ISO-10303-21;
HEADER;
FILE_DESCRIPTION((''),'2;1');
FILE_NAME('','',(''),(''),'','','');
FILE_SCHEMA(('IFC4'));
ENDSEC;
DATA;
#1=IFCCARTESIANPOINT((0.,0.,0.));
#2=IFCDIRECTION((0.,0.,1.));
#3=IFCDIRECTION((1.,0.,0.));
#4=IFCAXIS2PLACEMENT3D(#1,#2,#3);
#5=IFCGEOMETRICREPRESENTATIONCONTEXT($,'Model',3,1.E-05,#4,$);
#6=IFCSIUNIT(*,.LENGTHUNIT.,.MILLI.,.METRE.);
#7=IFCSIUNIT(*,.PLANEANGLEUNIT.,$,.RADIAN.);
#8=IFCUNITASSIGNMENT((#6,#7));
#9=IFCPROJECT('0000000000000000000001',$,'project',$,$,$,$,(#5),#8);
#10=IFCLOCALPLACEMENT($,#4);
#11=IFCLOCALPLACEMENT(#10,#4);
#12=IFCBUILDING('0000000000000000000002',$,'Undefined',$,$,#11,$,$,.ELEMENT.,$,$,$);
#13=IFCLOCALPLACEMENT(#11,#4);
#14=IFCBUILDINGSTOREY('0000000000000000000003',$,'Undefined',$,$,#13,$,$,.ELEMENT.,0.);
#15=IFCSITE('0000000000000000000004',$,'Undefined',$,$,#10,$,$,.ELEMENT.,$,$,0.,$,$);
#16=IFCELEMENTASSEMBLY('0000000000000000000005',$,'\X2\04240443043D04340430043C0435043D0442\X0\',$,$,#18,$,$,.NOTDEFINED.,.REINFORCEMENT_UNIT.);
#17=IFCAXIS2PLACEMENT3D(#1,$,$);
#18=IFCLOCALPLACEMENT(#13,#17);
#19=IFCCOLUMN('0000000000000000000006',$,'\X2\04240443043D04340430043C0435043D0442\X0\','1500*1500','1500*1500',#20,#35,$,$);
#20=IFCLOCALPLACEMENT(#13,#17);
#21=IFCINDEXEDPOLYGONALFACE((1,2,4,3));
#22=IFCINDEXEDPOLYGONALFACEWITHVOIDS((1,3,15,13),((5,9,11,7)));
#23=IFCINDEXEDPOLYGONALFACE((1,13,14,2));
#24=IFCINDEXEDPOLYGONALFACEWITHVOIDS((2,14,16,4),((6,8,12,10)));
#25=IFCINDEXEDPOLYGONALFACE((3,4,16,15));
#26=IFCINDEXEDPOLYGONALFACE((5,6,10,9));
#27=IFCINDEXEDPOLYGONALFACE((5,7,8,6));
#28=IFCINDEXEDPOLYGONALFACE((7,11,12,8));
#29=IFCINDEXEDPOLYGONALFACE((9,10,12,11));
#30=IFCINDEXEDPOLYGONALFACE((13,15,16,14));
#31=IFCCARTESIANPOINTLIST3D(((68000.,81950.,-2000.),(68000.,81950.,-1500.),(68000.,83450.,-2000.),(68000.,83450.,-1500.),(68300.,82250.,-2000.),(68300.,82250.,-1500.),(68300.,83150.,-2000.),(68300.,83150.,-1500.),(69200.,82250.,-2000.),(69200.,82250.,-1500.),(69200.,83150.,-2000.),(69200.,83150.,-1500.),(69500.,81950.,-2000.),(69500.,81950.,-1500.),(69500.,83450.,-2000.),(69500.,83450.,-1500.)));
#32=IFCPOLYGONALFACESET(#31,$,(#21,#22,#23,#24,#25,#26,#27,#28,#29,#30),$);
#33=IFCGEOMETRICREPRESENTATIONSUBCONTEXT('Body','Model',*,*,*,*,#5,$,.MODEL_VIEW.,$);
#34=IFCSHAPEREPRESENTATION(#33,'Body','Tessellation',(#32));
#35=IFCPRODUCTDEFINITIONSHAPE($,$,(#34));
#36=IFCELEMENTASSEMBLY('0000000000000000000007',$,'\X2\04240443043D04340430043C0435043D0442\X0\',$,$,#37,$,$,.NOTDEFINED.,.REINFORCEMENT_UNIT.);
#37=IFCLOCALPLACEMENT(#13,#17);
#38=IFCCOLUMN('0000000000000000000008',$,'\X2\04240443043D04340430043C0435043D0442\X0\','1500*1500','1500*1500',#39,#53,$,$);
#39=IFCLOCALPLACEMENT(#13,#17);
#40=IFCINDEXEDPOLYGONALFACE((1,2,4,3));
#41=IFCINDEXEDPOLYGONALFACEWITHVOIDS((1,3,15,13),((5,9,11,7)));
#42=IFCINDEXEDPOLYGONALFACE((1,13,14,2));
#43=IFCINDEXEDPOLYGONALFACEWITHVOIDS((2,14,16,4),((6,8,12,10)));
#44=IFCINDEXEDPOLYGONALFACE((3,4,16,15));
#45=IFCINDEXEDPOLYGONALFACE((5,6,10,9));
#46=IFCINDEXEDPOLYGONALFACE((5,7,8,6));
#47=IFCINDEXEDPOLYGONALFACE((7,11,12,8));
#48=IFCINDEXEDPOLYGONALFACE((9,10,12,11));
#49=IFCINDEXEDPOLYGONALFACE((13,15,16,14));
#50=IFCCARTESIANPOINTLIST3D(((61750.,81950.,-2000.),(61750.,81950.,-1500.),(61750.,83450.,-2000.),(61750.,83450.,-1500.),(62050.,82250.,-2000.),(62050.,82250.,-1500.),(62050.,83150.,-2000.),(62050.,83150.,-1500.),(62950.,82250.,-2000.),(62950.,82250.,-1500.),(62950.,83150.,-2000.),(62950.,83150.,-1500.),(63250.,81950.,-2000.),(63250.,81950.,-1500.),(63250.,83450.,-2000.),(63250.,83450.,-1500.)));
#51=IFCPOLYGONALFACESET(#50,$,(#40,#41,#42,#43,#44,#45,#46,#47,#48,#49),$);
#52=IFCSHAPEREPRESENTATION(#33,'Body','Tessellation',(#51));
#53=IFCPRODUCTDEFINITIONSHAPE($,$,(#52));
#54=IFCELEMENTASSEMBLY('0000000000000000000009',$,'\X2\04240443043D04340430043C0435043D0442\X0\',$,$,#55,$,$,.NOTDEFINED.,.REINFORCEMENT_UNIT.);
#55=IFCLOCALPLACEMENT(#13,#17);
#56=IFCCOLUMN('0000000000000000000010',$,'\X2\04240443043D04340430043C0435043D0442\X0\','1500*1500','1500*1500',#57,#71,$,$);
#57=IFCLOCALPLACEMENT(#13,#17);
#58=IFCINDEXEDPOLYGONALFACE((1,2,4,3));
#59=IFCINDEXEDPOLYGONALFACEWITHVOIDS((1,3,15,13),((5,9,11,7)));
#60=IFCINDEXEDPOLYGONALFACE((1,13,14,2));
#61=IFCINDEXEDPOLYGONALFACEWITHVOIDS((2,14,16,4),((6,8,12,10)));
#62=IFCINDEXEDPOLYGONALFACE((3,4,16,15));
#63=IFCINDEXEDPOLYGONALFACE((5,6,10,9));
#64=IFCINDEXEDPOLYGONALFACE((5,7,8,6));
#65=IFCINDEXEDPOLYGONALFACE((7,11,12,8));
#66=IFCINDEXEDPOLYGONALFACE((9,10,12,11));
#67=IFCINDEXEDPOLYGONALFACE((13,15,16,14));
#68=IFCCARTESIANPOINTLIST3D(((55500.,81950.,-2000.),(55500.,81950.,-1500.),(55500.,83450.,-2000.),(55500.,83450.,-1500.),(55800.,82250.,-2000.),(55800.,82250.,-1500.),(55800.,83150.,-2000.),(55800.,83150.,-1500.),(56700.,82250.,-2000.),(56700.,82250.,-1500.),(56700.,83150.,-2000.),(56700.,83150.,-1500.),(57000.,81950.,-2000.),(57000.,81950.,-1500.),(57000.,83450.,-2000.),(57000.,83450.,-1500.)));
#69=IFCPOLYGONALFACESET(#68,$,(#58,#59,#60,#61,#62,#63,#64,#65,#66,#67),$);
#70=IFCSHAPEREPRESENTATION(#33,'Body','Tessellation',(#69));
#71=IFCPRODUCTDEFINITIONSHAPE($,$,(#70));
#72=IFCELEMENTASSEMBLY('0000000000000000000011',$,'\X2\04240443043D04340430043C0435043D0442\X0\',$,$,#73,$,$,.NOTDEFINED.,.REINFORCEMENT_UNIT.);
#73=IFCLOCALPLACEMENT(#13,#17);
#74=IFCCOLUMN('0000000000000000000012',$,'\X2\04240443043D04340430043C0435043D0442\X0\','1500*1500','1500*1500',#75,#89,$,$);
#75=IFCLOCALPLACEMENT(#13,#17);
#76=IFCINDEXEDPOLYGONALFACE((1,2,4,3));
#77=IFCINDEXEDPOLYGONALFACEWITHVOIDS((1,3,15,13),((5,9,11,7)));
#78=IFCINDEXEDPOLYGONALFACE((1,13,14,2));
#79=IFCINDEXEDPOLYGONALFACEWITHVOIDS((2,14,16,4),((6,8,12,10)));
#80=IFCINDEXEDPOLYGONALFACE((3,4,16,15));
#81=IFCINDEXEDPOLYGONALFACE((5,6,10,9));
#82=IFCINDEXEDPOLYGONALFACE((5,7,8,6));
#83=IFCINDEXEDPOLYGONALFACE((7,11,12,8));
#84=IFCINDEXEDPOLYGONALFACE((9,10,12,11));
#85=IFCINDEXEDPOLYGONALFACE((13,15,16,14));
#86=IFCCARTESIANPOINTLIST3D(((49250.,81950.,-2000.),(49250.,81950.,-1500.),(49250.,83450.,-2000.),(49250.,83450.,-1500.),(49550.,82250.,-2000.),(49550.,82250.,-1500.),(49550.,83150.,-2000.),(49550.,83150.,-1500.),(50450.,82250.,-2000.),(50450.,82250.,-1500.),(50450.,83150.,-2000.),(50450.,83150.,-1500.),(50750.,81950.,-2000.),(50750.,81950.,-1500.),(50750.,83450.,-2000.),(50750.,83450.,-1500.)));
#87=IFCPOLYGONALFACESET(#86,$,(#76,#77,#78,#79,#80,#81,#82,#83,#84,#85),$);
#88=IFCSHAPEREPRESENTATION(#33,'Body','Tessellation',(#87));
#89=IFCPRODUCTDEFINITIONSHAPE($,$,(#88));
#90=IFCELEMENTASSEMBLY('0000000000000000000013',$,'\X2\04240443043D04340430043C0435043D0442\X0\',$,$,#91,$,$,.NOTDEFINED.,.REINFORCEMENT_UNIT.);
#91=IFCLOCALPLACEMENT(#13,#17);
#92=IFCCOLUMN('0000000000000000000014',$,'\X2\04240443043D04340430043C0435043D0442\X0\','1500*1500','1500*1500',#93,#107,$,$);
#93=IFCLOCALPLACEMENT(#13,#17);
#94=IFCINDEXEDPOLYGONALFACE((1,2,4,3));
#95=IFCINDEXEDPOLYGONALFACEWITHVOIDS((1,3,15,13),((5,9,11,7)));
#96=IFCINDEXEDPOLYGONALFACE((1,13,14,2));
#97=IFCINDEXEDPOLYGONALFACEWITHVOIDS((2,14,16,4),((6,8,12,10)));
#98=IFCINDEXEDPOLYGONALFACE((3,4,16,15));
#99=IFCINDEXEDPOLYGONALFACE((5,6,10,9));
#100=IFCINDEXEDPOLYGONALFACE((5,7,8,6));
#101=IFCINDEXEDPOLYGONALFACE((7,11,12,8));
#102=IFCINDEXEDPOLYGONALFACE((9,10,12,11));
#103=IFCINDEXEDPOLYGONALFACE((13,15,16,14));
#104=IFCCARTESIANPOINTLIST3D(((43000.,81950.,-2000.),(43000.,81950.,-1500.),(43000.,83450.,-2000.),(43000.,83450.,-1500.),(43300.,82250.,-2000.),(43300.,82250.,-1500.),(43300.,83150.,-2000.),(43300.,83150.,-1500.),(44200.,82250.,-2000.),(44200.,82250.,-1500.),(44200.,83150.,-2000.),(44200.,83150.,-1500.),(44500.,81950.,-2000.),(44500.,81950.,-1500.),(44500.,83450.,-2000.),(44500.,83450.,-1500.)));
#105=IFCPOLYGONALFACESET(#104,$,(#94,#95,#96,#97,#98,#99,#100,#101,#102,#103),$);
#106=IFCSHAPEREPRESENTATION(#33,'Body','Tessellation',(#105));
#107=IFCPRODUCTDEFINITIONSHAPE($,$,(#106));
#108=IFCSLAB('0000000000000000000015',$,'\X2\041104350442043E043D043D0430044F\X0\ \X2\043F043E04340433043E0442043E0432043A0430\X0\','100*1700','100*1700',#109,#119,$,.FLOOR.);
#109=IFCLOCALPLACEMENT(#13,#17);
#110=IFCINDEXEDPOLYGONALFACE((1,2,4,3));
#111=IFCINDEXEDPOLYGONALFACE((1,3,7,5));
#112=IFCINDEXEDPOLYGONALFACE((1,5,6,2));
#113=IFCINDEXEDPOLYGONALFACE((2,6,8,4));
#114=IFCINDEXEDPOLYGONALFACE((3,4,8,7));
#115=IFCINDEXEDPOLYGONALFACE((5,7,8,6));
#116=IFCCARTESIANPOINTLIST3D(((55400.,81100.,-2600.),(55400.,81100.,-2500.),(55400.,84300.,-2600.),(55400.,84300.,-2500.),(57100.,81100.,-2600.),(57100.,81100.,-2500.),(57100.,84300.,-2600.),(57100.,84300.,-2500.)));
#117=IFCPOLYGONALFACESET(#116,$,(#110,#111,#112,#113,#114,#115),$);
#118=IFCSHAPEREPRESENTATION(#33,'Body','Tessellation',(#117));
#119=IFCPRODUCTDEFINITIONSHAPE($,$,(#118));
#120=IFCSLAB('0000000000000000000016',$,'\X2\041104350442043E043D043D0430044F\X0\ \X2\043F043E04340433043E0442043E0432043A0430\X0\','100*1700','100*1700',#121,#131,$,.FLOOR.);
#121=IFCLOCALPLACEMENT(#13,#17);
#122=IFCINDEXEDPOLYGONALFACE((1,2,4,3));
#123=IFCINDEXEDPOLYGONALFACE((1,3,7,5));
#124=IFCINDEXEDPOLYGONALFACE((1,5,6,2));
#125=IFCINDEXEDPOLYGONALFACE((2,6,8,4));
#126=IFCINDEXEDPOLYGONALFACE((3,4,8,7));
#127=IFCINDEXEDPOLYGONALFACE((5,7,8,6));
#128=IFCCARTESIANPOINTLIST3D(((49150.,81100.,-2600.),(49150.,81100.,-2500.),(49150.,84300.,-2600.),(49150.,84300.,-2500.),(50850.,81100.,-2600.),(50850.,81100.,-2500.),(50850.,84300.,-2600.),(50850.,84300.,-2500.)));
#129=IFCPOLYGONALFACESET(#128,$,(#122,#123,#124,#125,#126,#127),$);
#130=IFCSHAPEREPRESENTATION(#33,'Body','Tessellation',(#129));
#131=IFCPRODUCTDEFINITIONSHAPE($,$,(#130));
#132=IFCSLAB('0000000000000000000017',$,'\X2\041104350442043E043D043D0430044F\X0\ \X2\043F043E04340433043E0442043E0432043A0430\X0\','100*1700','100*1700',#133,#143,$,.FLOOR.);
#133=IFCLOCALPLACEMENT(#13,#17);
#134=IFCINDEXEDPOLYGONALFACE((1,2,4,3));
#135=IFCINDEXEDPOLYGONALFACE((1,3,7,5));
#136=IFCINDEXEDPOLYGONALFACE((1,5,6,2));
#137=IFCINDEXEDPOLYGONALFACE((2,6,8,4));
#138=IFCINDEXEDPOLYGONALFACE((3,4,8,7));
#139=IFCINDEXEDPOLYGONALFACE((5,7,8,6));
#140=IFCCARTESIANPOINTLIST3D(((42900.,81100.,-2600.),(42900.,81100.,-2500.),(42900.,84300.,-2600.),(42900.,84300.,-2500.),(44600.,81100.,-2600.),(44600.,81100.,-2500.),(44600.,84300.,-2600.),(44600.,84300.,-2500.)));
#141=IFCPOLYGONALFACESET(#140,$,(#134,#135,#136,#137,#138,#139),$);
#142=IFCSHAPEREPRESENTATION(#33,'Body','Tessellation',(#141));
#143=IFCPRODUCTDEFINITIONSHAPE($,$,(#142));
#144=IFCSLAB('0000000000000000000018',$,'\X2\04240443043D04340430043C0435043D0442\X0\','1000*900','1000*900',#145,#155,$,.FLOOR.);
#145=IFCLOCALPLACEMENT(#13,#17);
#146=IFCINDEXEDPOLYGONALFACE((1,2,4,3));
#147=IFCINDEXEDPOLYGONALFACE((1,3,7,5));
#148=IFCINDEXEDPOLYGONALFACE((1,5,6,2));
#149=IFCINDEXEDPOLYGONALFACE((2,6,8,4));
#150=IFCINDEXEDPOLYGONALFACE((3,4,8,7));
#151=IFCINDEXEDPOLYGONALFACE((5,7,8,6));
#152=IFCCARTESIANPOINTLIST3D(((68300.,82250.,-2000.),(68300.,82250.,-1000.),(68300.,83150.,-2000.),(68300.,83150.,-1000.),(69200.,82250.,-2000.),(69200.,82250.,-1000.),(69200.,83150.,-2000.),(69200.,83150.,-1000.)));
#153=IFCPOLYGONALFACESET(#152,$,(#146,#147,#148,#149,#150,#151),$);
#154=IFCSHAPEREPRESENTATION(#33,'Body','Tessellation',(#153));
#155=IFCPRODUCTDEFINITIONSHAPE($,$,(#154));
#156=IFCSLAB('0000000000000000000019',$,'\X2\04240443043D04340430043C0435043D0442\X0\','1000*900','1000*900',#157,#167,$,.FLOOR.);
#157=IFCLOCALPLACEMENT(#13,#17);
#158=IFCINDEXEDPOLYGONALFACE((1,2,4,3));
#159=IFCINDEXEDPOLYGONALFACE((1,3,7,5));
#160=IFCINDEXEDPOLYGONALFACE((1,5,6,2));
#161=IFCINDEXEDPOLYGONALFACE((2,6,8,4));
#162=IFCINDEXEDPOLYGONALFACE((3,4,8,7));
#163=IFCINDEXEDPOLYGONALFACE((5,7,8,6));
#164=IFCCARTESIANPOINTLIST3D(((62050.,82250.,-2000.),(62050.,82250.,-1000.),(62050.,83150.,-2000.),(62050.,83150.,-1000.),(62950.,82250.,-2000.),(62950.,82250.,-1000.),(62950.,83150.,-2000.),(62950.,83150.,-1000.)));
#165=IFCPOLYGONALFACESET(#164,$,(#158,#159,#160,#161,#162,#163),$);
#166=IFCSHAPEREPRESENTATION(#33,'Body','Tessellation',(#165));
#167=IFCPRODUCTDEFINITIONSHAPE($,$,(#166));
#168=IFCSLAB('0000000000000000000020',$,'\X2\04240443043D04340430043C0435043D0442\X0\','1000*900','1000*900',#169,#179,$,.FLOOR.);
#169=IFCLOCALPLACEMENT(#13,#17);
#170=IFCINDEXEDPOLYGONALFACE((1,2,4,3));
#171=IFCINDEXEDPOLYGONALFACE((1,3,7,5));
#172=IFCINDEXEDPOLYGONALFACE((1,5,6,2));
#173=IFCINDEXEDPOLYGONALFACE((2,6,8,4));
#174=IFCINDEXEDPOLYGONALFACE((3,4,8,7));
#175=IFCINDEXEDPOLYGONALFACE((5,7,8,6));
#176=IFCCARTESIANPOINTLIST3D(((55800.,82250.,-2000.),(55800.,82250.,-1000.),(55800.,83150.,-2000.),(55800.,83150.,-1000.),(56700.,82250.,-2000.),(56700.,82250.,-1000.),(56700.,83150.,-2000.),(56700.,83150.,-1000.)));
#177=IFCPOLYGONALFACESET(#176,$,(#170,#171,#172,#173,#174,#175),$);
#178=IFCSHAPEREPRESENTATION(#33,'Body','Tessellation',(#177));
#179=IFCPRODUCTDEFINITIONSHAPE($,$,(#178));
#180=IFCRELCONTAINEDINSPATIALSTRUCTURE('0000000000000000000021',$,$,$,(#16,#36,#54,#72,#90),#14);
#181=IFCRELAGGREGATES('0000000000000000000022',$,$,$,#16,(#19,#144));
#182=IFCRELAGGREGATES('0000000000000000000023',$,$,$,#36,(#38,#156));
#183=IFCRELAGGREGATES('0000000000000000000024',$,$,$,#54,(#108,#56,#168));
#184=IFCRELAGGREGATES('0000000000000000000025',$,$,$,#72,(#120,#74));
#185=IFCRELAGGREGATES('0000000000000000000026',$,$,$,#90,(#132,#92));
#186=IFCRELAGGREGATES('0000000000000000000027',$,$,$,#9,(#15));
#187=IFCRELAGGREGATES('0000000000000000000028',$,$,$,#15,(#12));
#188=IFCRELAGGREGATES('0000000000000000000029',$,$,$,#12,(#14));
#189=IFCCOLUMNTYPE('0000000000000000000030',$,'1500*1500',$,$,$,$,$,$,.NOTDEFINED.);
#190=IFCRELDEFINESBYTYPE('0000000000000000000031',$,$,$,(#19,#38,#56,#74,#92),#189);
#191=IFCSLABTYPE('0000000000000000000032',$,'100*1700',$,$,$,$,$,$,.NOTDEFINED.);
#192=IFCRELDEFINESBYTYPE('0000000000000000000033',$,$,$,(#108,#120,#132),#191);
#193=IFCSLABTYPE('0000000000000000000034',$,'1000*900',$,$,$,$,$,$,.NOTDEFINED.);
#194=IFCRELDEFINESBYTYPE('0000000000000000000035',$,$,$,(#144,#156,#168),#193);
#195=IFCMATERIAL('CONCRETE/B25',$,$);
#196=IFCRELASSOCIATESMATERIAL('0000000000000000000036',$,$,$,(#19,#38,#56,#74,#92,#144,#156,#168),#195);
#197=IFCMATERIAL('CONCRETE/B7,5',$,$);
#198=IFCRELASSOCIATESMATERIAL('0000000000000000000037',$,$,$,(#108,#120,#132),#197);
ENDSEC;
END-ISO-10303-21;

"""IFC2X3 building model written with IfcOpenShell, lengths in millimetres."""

from ifc_helpers import new_model, si_unit, frame, origin_with_axes, origin_2d_with_axis, place, context, subcontext, project, spatial, polyline, rectangle, outline, extrude, boolean, material, type_object, element, aggregate, save


model = new_model("IFC2X3")

# Units and contexts
model_context = context("Model", 3, precision=1e-05, world=origin_with_axes())
body_context = subcontext(model_context, "Body", "Model", "MODEL_VIEW")
ifc_project = project(units=[si_unit("LENGTHUNIT", "METRE", prefix="MILLI"), si_unit("PLANEANGLEUNIT", "RADIAN")], contexts=[model_context])

# Site, building, storey
site_placement = place(None, origin_with_axes())
site = spatial("IfcSite", under=ifc_project, at=site_placement, Name="Undefined", CompositionType="ELEMENT", RefElevation=0.0)
building_placement = place(site_placement, origin_with_axes())
building = spatial("IfcBuilding", under=site, at=building_placement, Name="Undefined", CompositionType="ELEMENT")
storey_placement = place(building_placement, origin_with_axes())
storey = spatial("IfcBuildingStorey", under=building, at=storey_placement, Name="Undefined", CompositionType="ELEMENT", Elevation=0.0)

# Element assemblies, columns
assembly_1_placement = place(storey_placement, origin_with_axes())
assembly_1 = element("IfcElementAssembly", 1, at=assembly_1_placement, inside=storey, Name="Фундамент", AssemblyPlace="NOTDEFINED", PredefinedType="REINFORCEMENT_UNIT")
ifc_material_1 = material(Name="CONCRETE/B25")
column_type = type_object("IfcColumnType", Name="1500*1500", PredefinedType="NOTDEFINED")
column_1_placement = place(assembly_1_placement, frame((68750.0, 82700.0, -2000.0), z_axis=(0.0, 0.0, 1.0), x_axis=(0.0, -1.0, 0.0)))
column_1 = element("IfcColumn", 2, at=column_1_placement, type_object=column_type, material=ifc_material_1, Name="Фундамент", Description="1500*1500", ObjectType="1500*1500", context=body_context, shape_type="CSG", body=[
    boolean("DIFFERENCE", extrude(rectangle(XDim=1500.0, YDim=1500.0, at=origin_2d_with_axis()), frame((0.0, 0.0, 500.0), z_axis=(0.0, 0.0, -1.0), x_axis=(0.0, 1.0, 0.0)), (0.0, 0.0, 1.0), 500.0), extrude(outline(polyline([(0.0, 0.0), (900.0, 0.0), (900.0, 900.0), (0.0, 900.0), (0.0, 0.0)])), frame((-450.0, -450.0, -100.0), z_axis=(0.0, 0.0, 1.0), x_axis=(1.0, 0.0, 0.0)), (0.0, 0.0, 1.0), 700.0)),
])
assembly_2_placement = place(storey_placement, origin_with_axes())
assembly_2 = element("IfcElementAssembly", 3, at=assembly_2_placement, inside=storey, Name="Фундамент", AssemblyPlace="NOTDEFINED", PredefinedType="REINFORCEMENT_UNIT")
column_2_placement = place(assembly_2_placement, frame((62500.0, 82700.0, -2000.0), z_axis=(0.0, 0.0, 1.0), x_axis=(0.0, -1.0, 0.0)))
column_2 = element("IfcColumn", 4, at=column_2_placement, type_object=column_type, material=ifc_material_1, Name="Фундамент", Description="1500*1500", ObjectType="1500*1500", context=body_context, shape_type="CSG", body=[
    boolean("DIFFERENCE", extrude(rectangle(XDim=1500.0, YDim=1500.0, at=origin_2d_with_axis()), frame((0.0, 0.0, 500.0), z_axis=(0.0, 0.0, -1.0), x_axis=(0.0, 1.0, 0.0)), (0.0, 0.0, 1.0), 500.0), extrude(outline(polyline([(0.0, 0.0), (900.0, 0.0), (900.0, 900.0), (0.0, 900.0), (0.0, 0.0)])), frame((-450.0, -450.0, -100.0), z_axis=(0.0, 0.0, 1.0), x_axis=(1.0, 0.0, 0.0)), (0.0, 0.0, 1.0), 700.0)),
])
assembly_3_placement = place(storey_placement, origin_with_axes())
assembly_3 = element("IfcElementAssembly", 5, at=assembly_3_placement, inside=storey, Name="Фундамент", AssemblyPlace="NOTDEFINED", PredefinedType="REINFORCEMENT_UNIT")
column_3_placement = place(assembly_3_placement, frame((56250.0, 82700.0, -2000.0), z_axis=(0.0, 0.0, 1.0), x_axis=(0.0, -1.0, 0.0)))
column_3 = element("IfcColumn", 6, at=column_3_placement, type_object=column_type, material=ifc_material_1, Name="Фундамент", Description="1500*1500", ObjectType="1500*1500", context=body_context, shape_type="CSG", body=[
    boolean("DIFFERENCE", extrude(rectangle(XDim=1500.0, YDim=1500.0, at=origin_2d_with_axis()), frame((0.0, 0.0, 500.0), z_axis=(0.0, 0.0, -1.0), x_axis=(0.0, 1.0, 0.0)), (0.0, 0.0, 1.0), 500.0), extrude(outline(polyline([(0.0, 0.0), (900.0, 0.0), (900.0, 900.0), (0.0, 900.0), (0.0, 0.0)])), frame((-450.0, -450.0, -100.0), z_axis=(0.0, 0.0, 1.0), x_axis=(1.0, 0.0, 0.0)), (0.0, 0.0, 1.0), 700.0)),
])
assembly_4_placement = place(storey_placement, origin_with_axes())
assembly_4 = element("IfcElementAssembly", 7, at=assembly_4_placement, inside=storey, Name="Фундамент", AssemblyPlace="NOTDEFINED", PredefinedType="REINFORCEMENT_UNIT")
column_4_placement = place(assembly_4_placement, frame((50000.0, 82700.0, -2000.0), z_axis=(0.0, 0.0, 1.0), x_axis=(0.0, -1.0, 0.0)))
column_4 = element("IfcColumn", 8, at=column_4_placement, type_object=column_type, material=ifc_material_1, Name="Фундамент", Description="1500*1500", ObjectType="1500*1500", context=body_context, shape_type="CSG", body=[
    boolean("DIFFERENCE", extrude(rectangle(XDim=1500.0, YDim=1500.0, at=origin_2d_with_axis()), frame((0.0, 0.0, 500.0), z_axis=(0.0, 0.0, -1.0), x_axis=(0.0, 1.0, 0.0)), (0.0, 0.0, 1.0), 500.0), extrude(outline(polyline([(0.0, 0.0), (900.0, 0.0), (900.0, 900.0), (0.0, 900.0), (0.0, 0.0)])), frame((-450.0, -450.0, -100.0), z_axis=(0.0, 0.0, 1.0), x_axis=(1.0, 0.0, 0.0)), (0.0, 0.0, 1.0), 700.0)),
])
assembly_5_placement = place(storey_placement, origin_with_axes())
assembly_5 = element("IfcElementAssembly", 9, at=assembly_5_placement, inside=storey, Name="Фундамент", AssemblyPlace="NOTDEFINED", PredefinedType="REINFORCEMENT_UNIT")
column_5_placement = place(assembly_5_placement, frame((43750.0, 82700.0, -2000.0), z_axis=(0.0, 0.0, 1.0), x_axis=(0.0, -1.0, 0.0)))
column_5 = element("IfcColumn", 10, at=column_5_placement, type_object=column_type, material=ifc_material_1, Name="Фундамент", Description="1500*1500", ObjectType="1500*1500", context=body_context, shape_type="CSG", body=[
    boolean("DIFFERENCE", extrude(rectangle(XDim=1500.0, YDim=1500.0, at=origin_2d_with_axis()), frame((0.0, 0.0, 500.0), z_axis=(0.0, 0.0, -1.0), x_axis=(0.0, 1.0, 0.0)), (0.0, 0.0, 1.0), 500.0), extrude(outline(polyline([(0.0, 0.0), (900.0, 0.0), (900.0, 900.0), (0.0, 900.0), (0.0, 0.0)])), frame((-450.0, -450.0, -100.0), z_axis=(0.0, 0.0, 1.0), x_axis=(1.0, 0.0, 0.0)), (0.0, 0.0, 1.0), 700.0)),
])

# Slabs
ifc_material_2 = material(Name="CONCRETE/B7,5")
slab_type_1 = type_object("IfcSlabType", Name="100*1700", PredefinedType="NOTDEFINED")
slab_1_placement = place(assembly_3_placement, frame((55400.0, 84300.0, -2550.0), z_axis=(0.0, 0.0, 1.0), x_axis=(0.0, -1.0, 0.0)))
slab_1 = element("IfcSlab", 11, at=slab_1_placement, type_object=slab_type_1, material=ifc_material_2, Name="Бетонная подготовка", Description="100*1700", ObjectType="100*1700", PredefinedType="FLOOR", context=body_context, shape_type="SweptSolid", body=[
    extrude(outline(polyline([(0.0, 0.0), (3200.0, 0.0), (3200.0, 1700.0), (0.0, 1700.0), (0.0, 0.0)])), frame((0.0, 0.0, -50.0), z_axis=(0.0, 0.0, 1.0), x_axis=(1.0, 0.0, 0.0)), (0.0, 0.0, 1.0), 100.0),
])
slab_2_placement = place(assembly_4_placement, frame((49150.0, 84300.0, -2550.0), z_axis=(0.0, 0.0, 1.0), x_axis=(0.0, -1.0, 0.0)))
slab_2 = element("IfcSlab", 12, at=slab_2_placement, type_object=slab_type_1, material=ifc_material_2, Name="Бетонная подготовка", Description="100*1700", ObjectType="100*1700", PredefinedType="FLOOR", context=body_context, shape_type="SweptSolid", body=[
    extrude(outline(polyline([(0.0, 0.0), (3200.0, 0.0), (3200.0, 1700.0), (0.0, 1700.0), (0.0, 0.0)])), frame((0.0, 0.0, -50.0), z_axis=(0.0, 0.0, 1.0), x_axis=(1.0, 0.0, 0.0)), (0.0, 0.0, 1.0), 100.0),
])
slab_3_placement = place(assembly_5_placement, frame((42900.0, 84300.0, -2550.0), z_axis=(0.0, 0.0, 1.0), x_axis=(0.0, -1.0, 0.0)))
slab_3 = element("IfcSlab", 13, at=slab_3_placement, type_object=slab_type_1, material=ifc_material_2, Name="Бетонная подготовка", Description="100*1700", ObjectType="100*1700", PredefinedType="FLOOR", context=body_context, shape_type="SweptSolid", body=[
    extrude(outline(polyline([(0.0, 0.0), (3200.0, 0.0), (3200.0, 1700.0), (0.0, 1700.0), (0.0, 0.0)])), frame((0.0, 0.0, -50.0), z_axis=(0.0, 0.0, 1.0), x_axis=(1.0, 0.0, 0.0)), (0.0, 0.0, 1.0), 100.0),
])
slab_type_2 = type_object("IfcSlabType", Name="1000*900", PredefinedType="NOTDEFINED")
slab_4_placement = place(assembly_1_placement, frame((68300.0, 83150.0, -1500.0), z_axis=(0.0, 0.0, 1.0), x_axis=(0.0, -1.0, 0.0)))
slab_4 = element("IfcSlab", 14, at=slab_4_placement, type_object=slab_type_2, material=ifc_material_1, Name="Фундамент", Description="1000*900", ObjectType="1000*900", PredefinedType="FLOOR", context=body_context, shape_type="SweptSolid", body=[
    extrude(outline(polyline([(0.0, 0.0), (900.0, 0.0), (900.0, 900.0), (0.0, 900.0), (0.0, 0.0)])), frame((0.0, 0.0, -500.0), z_axis=(0.0, 0.0, 1.0), x_axis=(1.0, 0.0, 0.0)), (0.0, 0.0, 1.0), 1000.0),
])
slab_5_placement = place(assembly_2_placement, frame((62050.0, 83150.0, -1500.0), z_axis=(0.0, 0.0, 1.0), x_axis=(0.0, -1.0, 0.0)))
slab_5 = element("IfcSlab", 15, at=slab_5_placement, type_object=slab_type_2, material=ifc_material_1, Name="Фундамент", Description="1000*900", ObjectType="1000*900", PredefinedType="FLOOR", context=body_context, shape_type="SweptSolid", body=[
    extrude(outline(polyline([(0.0, 0.0), (900.0, 0.0), (900.0, 900.0), (0.0, 900.0), (0.0, 0.0)])), frame((0.0, 0.0, -500.0), z_axis=(0.0, 0.0, 1.0), x_axis=(1.0, 0.0, 0.0)), (0.0, 0.0, 1.0), 1000.0),
])
slab_6_placement = place(assembly_3_placement, frame((55800.0, 83150.0, -1500.0), z_axis=(0.0, 0.0, 1.0), x_axis=(0.0, -1.0, 0.0)))
slab_6 = element("IfcSlab", 16, at=slab_6_placement, type_object=slab_type_2, material=ifc_material_1, Name="Фундамент", Description="1000*900", ObjectType="1000*900", PredefinedType="FLOOR", context=body_context, shape_type="SweptSolid", body=[
    extrude(outline(polyline([(0.0, 0.0), (900.0, 0.0), (900.0, 900.0), (0.0, 900.0), (0.0, 0.0)])), frame((0.0, 0.0, -500.0), z_axis=(0.0, 0.0, 1.0), x_axis=(1.0, 0.0, 0.0)), (0.0, 0.0, 1.0), 1000.0),
])

aggregate(assembly_1, [column_1, slab_4])
aggregate(assembly_2, [column_2, slab_5])
aggregate(assembly_3, [slab_1, column_3, slab_6])
aggregate(assembly_4, [slab_2, column_4])
aggregate(assembly_5, [slab_3, column_5])

save(model, "model.ifc")
